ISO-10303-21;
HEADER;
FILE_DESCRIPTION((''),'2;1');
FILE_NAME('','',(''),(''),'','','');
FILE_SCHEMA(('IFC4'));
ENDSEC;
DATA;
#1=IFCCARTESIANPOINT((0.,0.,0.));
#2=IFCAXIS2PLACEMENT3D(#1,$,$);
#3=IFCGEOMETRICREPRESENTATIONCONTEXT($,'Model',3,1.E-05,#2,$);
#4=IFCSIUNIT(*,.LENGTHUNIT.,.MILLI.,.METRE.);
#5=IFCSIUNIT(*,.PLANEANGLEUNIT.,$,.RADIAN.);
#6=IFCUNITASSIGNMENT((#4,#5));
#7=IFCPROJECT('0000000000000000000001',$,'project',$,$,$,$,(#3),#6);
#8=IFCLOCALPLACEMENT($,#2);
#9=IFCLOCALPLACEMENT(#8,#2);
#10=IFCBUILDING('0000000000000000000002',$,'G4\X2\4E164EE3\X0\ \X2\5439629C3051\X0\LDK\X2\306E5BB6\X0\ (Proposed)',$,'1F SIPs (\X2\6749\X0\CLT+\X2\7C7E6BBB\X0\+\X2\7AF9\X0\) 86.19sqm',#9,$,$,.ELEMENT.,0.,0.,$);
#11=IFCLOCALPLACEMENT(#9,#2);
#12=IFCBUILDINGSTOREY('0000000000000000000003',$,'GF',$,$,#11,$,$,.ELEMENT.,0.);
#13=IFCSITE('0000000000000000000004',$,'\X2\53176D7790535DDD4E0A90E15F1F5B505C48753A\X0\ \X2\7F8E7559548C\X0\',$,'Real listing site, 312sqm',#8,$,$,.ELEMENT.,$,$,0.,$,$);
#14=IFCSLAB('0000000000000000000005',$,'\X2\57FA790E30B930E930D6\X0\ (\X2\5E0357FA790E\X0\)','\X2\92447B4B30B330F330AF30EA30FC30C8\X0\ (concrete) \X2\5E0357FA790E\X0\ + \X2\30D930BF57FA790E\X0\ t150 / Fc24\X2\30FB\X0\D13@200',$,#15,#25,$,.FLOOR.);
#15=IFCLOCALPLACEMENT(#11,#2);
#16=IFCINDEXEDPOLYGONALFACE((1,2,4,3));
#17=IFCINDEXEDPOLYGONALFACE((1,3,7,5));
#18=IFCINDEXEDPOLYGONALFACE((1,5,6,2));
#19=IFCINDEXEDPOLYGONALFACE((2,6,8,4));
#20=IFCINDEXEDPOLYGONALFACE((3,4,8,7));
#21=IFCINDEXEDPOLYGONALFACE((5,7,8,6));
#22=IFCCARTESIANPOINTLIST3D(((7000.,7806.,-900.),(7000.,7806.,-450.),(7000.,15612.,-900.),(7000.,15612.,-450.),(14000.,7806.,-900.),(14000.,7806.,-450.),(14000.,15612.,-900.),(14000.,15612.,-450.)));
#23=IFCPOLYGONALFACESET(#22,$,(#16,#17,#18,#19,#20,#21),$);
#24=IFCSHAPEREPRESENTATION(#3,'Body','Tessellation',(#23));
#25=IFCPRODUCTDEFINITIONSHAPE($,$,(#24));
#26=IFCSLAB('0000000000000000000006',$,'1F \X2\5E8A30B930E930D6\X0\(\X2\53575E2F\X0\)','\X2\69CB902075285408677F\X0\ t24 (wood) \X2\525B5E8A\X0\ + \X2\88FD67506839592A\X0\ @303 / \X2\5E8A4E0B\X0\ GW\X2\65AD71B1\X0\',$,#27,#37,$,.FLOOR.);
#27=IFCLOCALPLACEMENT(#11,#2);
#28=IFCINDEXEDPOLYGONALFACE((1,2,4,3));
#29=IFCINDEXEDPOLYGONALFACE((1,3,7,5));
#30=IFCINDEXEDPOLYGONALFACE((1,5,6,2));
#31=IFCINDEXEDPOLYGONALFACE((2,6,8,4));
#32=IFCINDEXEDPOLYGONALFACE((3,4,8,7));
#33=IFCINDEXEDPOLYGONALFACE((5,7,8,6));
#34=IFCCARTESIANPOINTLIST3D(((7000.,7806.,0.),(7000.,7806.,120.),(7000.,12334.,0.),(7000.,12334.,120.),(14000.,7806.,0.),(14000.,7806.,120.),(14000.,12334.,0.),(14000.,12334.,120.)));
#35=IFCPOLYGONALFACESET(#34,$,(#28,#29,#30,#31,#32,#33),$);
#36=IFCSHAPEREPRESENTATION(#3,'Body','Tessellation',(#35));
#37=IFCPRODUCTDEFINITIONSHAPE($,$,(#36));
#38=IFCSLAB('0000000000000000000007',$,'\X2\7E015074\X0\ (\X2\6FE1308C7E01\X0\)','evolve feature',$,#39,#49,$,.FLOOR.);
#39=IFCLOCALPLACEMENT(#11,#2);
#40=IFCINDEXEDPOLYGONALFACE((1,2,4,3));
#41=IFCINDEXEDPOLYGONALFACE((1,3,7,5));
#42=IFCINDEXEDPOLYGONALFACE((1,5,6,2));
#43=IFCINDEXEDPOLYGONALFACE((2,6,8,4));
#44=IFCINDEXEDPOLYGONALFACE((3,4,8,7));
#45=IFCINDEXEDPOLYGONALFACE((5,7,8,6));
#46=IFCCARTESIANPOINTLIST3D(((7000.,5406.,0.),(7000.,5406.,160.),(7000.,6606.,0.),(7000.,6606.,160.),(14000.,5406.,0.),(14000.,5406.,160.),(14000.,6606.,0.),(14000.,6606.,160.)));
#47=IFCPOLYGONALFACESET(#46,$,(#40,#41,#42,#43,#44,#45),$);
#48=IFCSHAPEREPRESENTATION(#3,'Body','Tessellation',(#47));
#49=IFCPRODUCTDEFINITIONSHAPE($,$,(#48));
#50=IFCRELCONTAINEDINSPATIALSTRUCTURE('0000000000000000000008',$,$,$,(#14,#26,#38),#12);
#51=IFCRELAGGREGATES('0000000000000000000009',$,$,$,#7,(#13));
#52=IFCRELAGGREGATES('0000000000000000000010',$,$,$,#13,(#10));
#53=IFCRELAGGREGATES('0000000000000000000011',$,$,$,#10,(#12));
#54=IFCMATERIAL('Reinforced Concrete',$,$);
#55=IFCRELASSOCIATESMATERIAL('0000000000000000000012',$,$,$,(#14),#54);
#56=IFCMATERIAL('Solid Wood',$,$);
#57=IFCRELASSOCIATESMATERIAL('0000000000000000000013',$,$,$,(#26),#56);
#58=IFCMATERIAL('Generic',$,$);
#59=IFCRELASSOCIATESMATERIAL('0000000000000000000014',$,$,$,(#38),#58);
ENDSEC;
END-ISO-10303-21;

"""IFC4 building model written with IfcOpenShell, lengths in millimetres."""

from ifc_helpers import new_model, si_unit, frame, frame_2d, origin, place, context, project, spatial, rectangle, extrude, material, element, save


model = new_model("IFC4")

# Units and contexts
model_context = context("Model", 3, precision=1e-05, world=origin())
ifc_project = project(units=[si_unit("LENGTHUNIT", "METRE", prefix="MILLI"), si_unit("PLANEANGLEUNIT", "RADIAN")], contexts=[model_context])

# Site, building, storey
site_placement = place(None, origin())
site = spatial("IfcSite", under=ifc_project, at=site_placement, Name="北海道川上郡弟子屈町 美留和", ObjectType="Real listing site, 312sqm", CompositionType="ELEMENT", RefElevation=0.0)
building_placement = place(site_placement, origin())
building = spatial("IfcBuilding", under=site, at=building_placement, Name="G4世代 吹抜けLDKの家 (Proposed)", ObjectType="1F SIPs (杉CLT+籾殻+竹) 86.19sqm", CompositionType="ELEMENT", ElevationOfRefHeight=0.0, ElevationOfTerrain=0.0)
storey_placement = place(building_placement, origin())
storey = spatial("IfcBuildingStorey", under=building, at=storey_placement, Name="GF", CompositionType="ELEMENT", Elevation=0.0)

# Slabs
ifc_material_1 = material(Name="Reinforced Concrete")
slab_1_placement = place(storey_placement, frame((3500.0, 3903.0, -450.0)))
element("IfcSlab", 1, at=slab_1_placement, inside=storey, material=ifc_material_1, Name="基礎スラブ (布基礎)", Description="鉄筋コンクリート (concrete) 布基礎 + ベタ基礎 t150 / Fc24・D13@200", PredefinedType="FLOOR", context=model_context, shape_type="SweptSolid", body=[
    extrude(rectangle(XDim=7000.0, YDim=7806.0, at=frame_2d((3500.0, 3903.0))), frame((3500.0, 3903.0, -450.0)), (0.0, 0.0, 1.0), 450.0),
])
ifc_material_2 = material(Name="Solid Wood")
slab_2_placement = place(storey_placement, frame((3500.0, 3903.0, 0.0)))
element("IfcSlab", 2, at=slab_2_placement, inside=storey, material=ifc_material_2, Name="1F 床スラブ(南帯)", Description="構造用合板 t24 (wood) 剛床 + 製材根太 @303 / 床下 GW断熱", PredefinedType="FLOOR", context=model_context, shape_type="SweptSolid", body=[
    extrude(rectangle(XDim=7000.0, YDim=4528.0, at=frame_2d((3500.0, 2264.0))), frame((3500.0, 3903.0, 0.0)), (0.0, 0.0, 1.0), 120.0),
])
ifc_material_3 = material(Name="Generic")
slab_3_placement = place(storey_placement, frame((3500.0, 2703.0, 0.0)))
element("IfcSlab", 3, at=slab_3_placement, inside=storey, material=ifc_material_3, Name="縁側 (濡れ縁)", Description="evolve feature", PredefinedType="FLOOR", context=model_context, shape_type="SweptSolid", body=[
    extrude(rectangle(XDim=7000.0, YDim=1200.0, at=frame_2d((3500.0, 600.0))), frame((3500.0, 2703.0, 0.0)), (0.0, 0.0, 1.0), 160.0),
])

save(model, "model.ifc")
